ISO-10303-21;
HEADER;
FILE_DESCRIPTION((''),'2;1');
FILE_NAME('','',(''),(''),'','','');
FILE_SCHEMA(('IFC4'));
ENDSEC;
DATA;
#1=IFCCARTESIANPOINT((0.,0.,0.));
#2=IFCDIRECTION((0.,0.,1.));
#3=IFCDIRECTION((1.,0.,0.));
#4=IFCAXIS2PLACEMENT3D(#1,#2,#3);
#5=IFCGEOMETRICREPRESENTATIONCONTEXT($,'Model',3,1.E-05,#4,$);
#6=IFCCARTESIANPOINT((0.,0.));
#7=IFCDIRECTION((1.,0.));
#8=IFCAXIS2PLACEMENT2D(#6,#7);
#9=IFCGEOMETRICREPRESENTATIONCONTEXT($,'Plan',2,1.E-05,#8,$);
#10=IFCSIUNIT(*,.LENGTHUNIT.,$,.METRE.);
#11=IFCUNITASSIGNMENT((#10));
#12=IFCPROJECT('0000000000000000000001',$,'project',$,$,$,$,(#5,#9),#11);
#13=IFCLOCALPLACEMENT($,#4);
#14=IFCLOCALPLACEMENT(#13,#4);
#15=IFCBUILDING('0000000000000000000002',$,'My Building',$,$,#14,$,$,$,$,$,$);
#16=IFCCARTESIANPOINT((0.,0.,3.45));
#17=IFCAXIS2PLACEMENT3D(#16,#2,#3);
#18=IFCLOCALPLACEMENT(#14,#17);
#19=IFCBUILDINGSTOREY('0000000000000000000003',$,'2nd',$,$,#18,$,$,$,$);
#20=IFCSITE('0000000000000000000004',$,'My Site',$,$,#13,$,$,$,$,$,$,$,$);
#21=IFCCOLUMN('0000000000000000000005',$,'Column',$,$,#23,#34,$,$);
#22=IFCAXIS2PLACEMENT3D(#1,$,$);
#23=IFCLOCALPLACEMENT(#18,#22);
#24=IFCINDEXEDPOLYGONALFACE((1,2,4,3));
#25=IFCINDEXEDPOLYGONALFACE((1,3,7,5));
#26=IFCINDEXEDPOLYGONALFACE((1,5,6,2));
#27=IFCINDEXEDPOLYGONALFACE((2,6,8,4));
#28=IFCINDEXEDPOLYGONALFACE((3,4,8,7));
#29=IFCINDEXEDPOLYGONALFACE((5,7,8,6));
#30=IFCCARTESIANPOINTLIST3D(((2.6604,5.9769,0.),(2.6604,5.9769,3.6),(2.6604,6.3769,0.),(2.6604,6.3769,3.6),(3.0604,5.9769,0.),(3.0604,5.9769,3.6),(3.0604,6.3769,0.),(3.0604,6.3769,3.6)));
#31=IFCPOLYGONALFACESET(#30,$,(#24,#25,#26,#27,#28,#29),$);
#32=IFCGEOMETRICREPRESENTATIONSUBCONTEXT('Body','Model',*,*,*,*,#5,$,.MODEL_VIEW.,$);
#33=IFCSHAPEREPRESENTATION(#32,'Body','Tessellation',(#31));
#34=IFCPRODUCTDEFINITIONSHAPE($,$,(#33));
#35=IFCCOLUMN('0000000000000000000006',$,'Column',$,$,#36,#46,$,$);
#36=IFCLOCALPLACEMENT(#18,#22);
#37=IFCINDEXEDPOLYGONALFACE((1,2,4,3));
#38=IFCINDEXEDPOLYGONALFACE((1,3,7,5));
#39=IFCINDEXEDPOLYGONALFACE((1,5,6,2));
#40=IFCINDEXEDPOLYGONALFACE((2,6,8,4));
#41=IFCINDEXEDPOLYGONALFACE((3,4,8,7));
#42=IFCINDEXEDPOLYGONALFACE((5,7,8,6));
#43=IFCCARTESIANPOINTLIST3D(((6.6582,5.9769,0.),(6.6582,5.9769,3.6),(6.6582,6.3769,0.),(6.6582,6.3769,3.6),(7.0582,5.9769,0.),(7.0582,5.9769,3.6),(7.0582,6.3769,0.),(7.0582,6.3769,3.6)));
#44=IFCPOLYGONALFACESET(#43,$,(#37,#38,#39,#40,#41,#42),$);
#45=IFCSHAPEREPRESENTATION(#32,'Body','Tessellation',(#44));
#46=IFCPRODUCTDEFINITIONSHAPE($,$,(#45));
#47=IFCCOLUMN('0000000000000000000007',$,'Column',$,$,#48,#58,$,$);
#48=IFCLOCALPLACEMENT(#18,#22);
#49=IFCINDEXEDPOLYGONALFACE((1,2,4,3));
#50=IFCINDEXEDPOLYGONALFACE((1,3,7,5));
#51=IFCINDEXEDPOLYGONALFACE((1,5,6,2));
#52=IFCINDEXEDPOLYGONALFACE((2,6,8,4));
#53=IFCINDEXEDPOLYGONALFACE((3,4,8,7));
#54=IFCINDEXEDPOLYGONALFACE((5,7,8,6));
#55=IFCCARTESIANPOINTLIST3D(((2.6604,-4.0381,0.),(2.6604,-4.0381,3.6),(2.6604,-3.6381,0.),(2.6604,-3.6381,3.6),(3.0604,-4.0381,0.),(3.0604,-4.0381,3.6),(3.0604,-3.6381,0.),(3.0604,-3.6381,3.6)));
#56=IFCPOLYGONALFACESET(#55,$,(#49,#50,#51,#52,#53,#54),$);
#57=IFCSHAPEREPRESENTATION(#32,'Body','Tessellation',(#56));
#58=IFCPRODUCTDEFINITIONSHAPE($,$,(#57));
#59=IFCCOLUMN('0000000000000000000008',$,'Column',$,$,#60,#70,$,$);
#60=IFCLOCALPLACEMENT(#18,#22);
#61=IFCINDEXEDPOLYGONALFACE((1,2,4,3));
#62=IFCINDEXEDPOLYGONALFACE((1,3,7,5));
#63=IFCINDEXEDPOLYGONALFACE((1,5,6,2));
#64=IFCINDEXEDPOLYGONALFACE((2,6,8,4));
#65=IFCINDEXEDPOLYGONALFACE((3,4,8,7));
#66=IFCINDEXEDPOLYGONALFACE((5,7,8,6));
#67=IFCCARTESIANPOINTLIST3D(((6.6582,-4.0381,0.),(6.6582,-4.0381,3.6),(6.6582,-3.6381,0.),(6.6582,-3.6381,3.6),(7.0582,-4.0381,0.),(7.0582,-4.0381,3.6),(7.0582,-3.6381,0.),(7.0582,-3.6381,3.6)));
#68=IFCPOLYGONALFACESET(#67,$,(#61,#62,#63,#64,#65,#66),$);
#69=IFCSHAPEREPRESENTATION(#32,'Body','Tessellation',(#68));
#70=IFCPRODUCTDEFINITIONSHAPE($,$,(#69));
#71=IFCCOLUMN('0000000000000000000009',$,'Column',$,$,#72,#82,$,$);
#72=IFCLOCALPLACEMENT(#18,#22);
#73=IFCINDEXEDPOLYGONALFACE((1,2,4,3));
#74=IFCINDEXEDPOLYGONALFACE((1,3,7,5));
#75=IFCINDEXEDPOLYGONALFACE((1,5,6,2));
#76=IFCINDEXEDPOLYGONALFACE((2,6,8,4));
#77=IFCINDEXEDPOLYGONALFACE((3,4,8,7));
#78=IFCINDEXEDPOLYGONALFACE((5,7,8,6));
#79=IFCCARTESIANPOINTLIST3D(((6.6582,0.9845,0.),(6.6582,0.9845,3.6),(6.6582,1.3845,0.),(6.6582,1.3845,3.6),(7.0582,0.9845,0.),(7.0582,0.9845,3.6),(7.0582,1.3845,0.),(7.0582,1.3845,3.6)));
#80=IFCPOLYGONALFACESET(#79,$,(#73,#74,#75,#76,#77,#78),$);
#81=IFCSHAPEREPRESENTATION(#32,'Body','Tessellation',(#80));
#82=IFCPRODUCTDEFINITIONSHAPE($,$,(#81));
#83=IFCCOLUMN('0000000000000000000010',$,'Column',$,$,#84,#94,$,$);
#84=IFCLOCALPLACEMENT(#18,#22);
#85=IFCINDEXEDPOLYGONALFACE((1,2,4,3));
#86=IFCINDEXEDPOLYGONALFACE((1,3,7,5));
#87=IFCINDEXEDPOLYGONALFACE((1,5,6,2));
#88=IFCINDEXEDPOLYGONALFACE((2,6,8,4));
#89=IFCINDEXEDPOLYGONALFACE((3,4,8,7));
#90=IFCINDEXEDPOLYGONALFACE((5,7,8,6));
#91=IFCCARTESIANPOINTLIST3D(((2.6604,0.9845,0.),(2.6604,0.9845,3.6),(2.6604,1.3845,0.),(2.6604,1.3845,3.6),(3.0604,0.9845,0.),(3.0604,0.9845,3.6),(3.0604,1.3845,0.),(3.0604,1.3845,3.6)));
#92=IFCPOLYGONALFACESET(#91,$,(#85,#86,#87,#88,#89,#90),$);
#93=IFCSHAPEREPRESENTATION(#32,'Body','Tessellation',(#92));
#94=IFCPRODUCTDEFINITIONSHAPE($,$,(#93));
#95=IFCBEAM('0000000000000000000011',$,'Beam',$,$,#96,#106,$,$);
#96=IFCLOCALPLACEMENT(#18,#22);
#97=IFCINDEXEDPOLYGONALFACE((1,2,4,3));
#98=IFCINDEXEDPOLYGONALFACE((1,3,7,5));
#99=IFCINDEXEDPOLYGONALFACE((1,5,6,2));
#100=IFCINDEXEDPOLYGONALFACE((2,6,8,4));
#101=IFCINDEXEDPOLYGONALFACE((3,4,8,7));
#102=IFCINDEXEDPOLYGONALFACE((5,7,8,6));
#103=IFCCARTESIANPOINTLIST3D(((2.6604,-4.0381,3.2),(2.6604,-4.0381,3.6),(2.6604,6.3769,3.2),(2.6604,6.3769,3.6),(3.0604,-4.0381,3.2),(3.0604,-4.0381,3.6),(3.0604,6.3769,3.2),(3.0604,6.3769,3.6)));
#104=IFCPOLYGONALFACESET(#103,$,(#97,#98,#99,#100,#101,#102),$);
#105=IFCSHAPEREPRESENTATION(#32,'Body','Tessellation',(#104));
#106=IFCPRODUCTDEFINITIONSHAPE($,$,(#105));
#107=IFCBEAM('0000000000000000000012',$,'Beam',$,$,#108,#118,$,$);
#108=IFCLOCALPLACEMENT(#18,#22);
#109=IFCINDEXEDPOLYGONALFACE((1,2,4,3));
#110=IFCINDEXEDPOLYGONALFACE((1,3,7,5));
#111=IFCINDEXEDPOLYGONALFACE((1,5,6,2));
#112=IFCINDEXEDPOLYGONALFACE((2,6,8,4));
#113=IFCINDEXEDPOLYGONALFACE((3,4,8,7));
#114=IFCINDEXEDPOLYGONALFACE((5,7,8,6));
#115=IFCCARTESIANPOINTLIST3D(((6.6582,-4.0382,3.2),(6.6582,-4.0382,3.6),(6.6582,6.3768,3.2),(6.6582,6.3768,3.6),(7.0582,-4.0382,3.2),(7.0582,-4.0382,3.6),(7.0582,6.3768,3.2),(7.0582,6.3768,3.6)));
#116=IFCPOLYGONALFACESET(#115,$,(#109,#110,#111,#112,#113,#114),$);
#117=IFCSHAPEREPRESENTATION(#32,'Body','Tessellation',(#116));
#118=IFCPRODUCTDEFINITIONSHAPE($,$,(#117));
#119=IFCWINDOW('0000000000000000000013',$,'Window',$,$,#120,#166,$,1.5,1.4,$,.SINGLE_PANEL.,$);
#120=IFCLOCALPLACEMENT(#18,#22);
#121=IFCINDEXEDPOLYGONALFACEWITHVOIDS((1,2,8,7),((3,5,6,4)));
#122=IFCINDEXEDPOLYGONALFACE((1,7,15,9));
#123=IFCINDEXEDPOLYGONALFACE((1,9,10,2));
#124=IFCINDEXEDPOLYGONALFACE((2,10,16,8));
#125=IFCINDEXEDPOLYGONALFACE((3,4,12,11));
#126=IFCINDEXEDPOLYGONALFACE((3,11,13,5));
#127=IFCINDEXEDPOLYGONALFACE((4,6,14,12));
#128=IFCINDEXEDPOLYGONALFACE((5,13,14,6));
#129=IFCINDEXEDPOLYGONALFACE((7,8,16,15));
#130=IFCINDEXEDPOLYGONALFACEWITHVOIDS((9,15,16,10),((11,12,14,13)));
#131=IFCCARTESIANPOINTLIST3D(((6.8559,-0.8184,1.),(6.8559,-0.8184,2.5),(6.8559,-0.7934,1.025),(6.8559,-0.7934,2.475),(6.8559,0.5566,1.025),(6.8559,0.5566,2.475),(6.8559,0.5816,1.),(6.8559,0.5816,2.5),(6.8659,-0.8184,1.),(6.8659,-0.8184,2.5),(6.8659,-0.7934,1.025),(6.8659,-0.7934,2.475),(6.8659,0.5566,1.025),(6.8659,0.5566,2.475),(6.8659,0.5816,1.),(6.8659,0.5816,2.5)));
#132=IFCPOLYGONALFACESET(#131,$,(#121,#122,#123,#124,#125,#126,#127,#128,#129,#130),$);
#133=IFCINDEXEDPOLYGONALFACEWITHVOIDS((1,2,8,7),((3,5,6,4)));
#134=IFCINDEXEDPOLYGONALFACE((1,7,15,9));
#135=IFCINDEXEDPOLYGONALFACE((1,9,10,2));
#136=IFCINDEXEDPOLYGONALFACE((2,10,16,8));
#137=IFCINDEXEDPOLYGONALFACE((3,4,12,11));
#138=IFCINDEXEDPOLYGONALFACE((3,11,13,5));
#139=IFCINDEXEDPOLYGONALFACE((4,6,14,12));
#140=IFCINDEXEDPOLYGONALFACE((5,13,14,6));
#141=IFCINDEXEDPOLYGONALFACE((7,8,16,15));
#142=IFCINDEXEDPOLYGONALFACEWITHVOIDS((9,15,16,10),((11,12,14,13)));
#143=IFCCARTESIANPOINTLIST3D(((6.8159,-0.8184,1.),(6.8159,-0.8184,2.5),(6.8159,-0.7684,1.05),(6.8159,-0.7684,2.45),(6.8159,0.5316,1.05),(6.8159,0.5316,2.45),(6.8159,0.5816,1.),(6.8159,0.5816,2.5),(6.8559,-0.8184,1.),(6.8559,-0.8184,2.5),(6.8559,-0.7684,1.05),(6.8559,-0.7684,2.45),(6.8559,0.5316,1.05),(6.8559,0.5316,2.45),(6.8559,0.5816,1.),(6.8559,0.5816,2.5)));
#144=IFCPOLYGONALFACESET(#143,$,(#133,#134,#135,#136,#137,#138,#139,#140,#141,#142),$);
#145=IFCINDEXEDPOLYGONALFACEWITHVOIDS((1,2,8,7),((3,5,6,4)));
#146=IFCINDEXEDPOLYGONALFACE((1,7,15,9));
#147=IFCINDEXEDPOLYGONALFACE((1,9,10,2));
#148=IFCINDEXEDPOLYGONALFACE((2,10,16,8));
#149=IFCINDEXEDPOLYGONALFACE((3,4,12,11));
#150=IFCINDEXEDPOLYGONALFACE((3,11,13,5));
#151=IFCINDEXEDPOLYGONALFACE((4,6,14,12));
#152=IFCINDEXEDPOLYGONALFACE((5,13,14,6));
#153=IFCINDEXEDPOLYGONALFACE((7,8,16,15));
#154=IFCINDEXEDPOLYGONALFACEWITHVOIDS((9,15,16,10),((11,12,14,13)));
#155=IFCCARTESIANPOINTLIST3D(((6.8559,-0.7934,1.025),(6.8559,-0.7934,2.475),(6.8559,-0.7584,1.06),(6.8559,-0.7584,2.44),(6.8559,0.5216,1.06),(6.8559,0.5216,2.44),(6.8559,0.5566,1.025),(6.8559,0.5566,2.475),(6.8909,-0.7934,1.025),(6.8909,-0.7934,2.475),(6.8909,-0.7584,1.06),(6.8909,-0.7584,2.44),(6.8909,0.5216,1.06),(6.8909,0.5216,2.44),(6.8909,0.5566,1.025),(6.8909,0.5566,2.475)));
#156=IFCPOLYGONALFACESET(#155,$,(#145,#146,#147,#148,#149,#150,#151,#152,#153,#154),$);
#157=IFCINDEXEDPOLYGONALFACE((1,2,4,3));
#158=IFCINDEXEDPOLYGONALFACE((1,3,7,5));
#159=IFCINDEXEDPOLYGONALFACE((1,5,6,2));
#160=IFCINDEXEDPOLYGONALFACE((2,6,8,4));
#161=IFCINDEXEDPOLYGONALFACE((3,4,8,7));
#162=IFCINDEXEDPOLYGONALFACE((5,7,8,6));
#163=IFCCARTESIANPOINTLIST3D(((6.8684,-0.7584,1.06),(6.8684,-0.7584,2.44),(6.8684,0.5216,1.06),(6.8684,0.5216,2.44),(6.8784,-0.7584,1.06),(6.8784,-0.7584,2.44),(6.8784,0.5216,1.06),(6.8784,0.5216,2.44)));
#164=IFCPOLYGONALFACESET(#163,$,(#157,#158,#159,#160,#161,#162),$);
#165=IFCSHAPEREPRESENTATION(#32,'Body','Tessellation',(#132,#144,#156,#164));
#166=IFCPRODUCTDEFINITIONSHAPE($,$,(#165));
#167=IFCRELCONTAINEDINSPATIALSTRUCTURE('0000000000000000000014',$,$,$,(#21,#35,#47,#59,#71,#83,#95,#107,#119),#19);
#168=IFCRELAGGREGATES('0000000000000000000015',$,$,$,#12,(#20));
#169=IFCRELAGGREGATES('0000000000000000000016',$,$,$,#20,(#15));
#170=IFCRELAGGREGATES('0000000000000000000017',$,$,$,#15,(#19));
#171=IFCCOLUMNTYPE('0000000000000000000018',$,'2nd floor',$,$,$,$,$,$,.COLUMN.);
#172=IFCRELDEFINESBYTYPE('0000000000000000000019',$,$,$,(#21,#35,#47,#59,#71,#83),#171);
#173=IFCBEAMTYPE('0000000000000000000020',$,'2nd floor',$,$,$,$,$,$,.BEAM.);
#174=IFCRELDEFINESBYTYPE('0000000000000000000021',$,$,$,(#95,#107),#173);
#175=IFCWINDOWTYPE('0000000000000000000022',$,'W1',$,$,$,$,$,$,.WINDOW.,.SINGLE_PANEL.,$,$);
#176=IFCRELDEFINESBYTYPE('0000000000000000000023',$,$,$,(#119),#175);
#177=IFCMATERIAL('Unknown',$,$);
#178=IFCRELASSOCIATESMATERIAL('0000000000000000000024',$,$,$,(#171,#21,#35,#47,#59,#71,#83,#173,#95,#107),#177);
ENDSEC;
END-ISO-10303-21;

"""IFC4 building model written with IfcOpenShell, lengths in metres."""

from ifc_helpers import new_model, entity, si_unit, frame, origin_with_axes, origin_2d_with_axis, place, context, subcontext, project, spatial, line, indexed_curve, rectangle, outline, extrude, shape, source, transform, mapped, material, material_profile, profile_set, profile_usage, type_object, type_shapes, element, save


model = new_model("IFC4")

# Units and contexts
model_context = context("Model", 3, precision=1e-05, world=origin_with_axes())
plan_context = context("Plan", 2, precision=1e-05, world=origin_2d_with_axis())
body_context_1 = subcontext(model_context, "Body", "Model", "MODEL_VIEW")
body_context_2 = subcontext(plan_context, "Body", "Plan", "PLAN_VIEW")
ifc_project = project(units=[si_unit("LENGTHUNIT", "METRE")], contexts=[model_context, plan_context])

# Site, building, storey
site_placement = place(None, origin_with_axes())
site = spatial("IfcSite", under=ifc_project, at=site_placement, Name="My Site")
building_placement = place(site_placement, origin_with_axes())
building = spatial("IfcBuilding", under=site, at=building_placement, Name="My Building")
storey_placement = place(building_placement, frame((0.0, 0.0, 3.45), z_axis=(0.0, 0.0, 1.0), x_axis=(1.0, 0.0, 0.0)))
storey = spatial("IfcBuildingStorey", under=building, at=storey_placement, Name="2nd")

# Columns
ifc_material = material(Name="Unknown")
ifc_material_profile_1 = material_profile(ifc_material, rectangle(XDim=0.4, YDim=0.4))
ifc_profile_set_1 = profile_set([ifc_material_profile_1])
ifc_profile_usage_1 = profile_usage(ifc_profile_set_1, cardinal=5)
column_type = type_object("IfcColumnType", Name="2nd floor", PredefinedType="COLUMN", material=ifc_profile_set_1)
column_1_placement = place(storey_placement, frame((2.8604, 6.1769, 0.0), z_axis=(0.0, 0.0, 1.0), x_axis=(1.0, 0.0, 0.0)))
element("IfcColumn", 1, at=column_1_placement, inside=storey, type_object=column_type, material=ifc_profile_usage_1, Name="Column", context=body_context_1, shape_type="SweptSolid", body=[
    extrude(rectangle(XDim=0.4, YDim=0.4), origin_with_axes(), (0.0, 0.0, 1.0), 3.6),
])
ifc_profile_usage_2 = profile_usage(ifc_profile_set_1, cardinal=5)
column_2_placement = place(storey_placement, frame((6.8582, 6.1769, 0.0), z_axis=(0.0, 0.0, 1.0), x_axis=(1.0, 0.0, 0.0)))
element("IfcColumn", 2, at=column_2_placement, inside=storey, type_object=column_type, material=ifc_profile_usage_2, Name="Column", context=body_context_1, shape_type="SweptSolid", body=[
    extrude(rectangle(XDim=0.4, YDim=0.4), origin_with_axes(), (0.0, 0.0, 1.0), 3.6),
])
ifc_profile_usage_3 = profile_usage(ifc_profile_set_1, cardinal=5)
column_3_placement = place(storey_placement, frame((2.8604, -3.8381, 0.0), z_axis=(0.0, 0.0, 1.0), x_axis=(1.0, 0.0, 0.0)))
element("IfcColumn", 3, at=column_3_placement, inside=storey, type_object=column_type, material=ifc_profile_usage_3, Name="Column", context=body_context_1, shape_type="SweptSolid", body=[
    extrude(rectangle(XDim=0.4, YDim=0.4), origin_with_axes(), (0.0, 0.0, 1.0), 3.6),
])
ifc_profile_usage_4 = profile_usage(ifc_profile_set_1, cardinal=5)
column_4_placement = place(storey_placement, frame((6.8582, -3.8381, 0.0), z_axis=(0.0, 0.0, 1.0), x_axis=(1.0, 0.0, 0.0)))
element("IfcColumn", 4, at=column_4_placement, inside=storey, type_object=column_type, material=ifc_profile_usage_4, Name="Column", context=body_context_1, shape_type="SweptSolid", body=[
    extrude(rectangle(XDim=0.4, YDim=0.4), origin_with_axes(), (0.0, 0.0, 1.0), 3.6),
])
ifc_profile_usage_5 = profile_usage(ifc_profile_set_1, cardinal=5)
column_5_placement = place(storey_placement, frame((6.8582, 1.1845, 0.0), z_axis=(0.0, 0.0, 1.0), x_axis=(1.0, 0.0, 0.0)))
element("IfcColumn", 5, at=column_5_placement, inside=storey, type_object=column_type, material=ifc_profile_usage_5, Name="Column", context=body_context_1, shape_type="SweptSolid", body=[
    extrude(rectangle(XDim=0.4, YDim=0.4), origin_with_axes(), (0.0, 0.0, 1.0), 3.6),
])
ifc_profile_usage_6 = profile_usage(ifc_profile_set_1, cardinal=5)
column_6_placement = place(storey_placement, frame((2.8604, 1.1845, 0.0), z_axis=(0.0, 0.0, 1.0), x_axis=(1.0, 0.0, 0.0)))
element("IfcColumn", 6, at=column_6_placement, inside=storey, type_object=column_type, material=ifc_profile_usage_6, Name="Column", context=body_context_1, shape_type="SweptSolid", body=[
    extrude(rectangle(XDim=0.4, YDim=0.4), origin_with_axes(), (0.0, 0.0, 1.0), 3.6),
])

# Beams
ifc_material_profile_2 = material_profile(ifc_material, rectangle(XDim=0.4, YDim=0.4))
ifc_profile_set_2 = profile_set([ifc_material_profile_2])
ifc_profile_usage_7 = profile_usage(ifc_profile_set_2, cardinal=5)
beam_type = type_object("IfcBeamType", Name="2nd floor", PredefinedType="BEAM", material=ifc_profile_set_2)
beam_1_placement = place(storey_placement, frame((2.8604, 6.3769, 3.4), z_axis=(0.0, -1.0, 0.0), x_axis=(1.0, 0.0, 0.0)))
element("IfcBeam", 7, at=beam_1_placement, inside=storey, type_object=beam_type, material=ifc_profile_usage_7, Name="Beam", context=body_context_1, shape_type="SweptSolid", body=[
    extrude(rectangle(XDim=0.4, YDim=0.4), origin_with_axes(), (0.0, 0.0, 1.0), 10.415),
])
ifc_profile_usage_8 = profile_usage(ifc_profile_set_2, cardinal=5)
beam_2_placement = place(storey_placement, frame((6.8582, 6.3768, 3.4), z_axis=(0.0, -1.0, 0.0), x_axis=(1.0, 0.0, 0.0)))
element("IfcBeam", 8, at=beam_2_placement, inside=storey, type_object=beam_type, material=ifc_profile_usage_8, Name="Beam", context=body_context_1, shape_type="SweptSolid", body=[
    extrude(rectangle(XDim=0.4, YDim=0.4), origin_with_axes(), (0.0, 0.0, 1.0), 10.415),
])

# Window
window_type_1 = type_object("IfcWindowType", Name="W1", PartitioningType="SINGLE_PANEL", PredefinedType="WINDOW")
shared_shape_1 = source(origin_with_axes(), body_context_1, "Body", "SweptSolid", [
    extrude(outline(indexed_curve([(0.0, 0.0), (1.4, 0.0), (1.4, 1.5), (0.0, 1.5)], segments=[line(1, 2, 3, 4, 1)]), holes=[indexed_curve([(0.025, 0.025), (1.375, 0.025), (1.375, 1.475), (0.025, 1.475)], segments=[line(1, 2, 3, 4, 1)])]), frame((0.0, 0.09, 0.0), z_axis=(0.0, -1.0, 0.0), x_axis=(1.0, 0.0, 0.0)), (0.0, 0.0, -1.0), 0.01),
    extrude(outline(indexed_curve([(0.0, 0.0), (1.4, 0.0), (1.4, 1.5), (0.0, 1.5)], segments=[line(1, 2, 3, 4, 1)]), holes=[indexed_curve([(0.05, 0.05), (1.35, 0.05), (1.35, 1.45), (0.05, 1.45)], segments=[line(1, 2, 3, 4, 1)])]), frame((0.0, 0.05, 0.0), z_axis=(0.0, -1.0, 0.0), x_axis=(1.0, 0.0, 0.0)), (0.0, 0.0, -1.0), 0.04),
    extrude(outline(indexed_curve([(0.0, 0.0), (1.35, 0.0), (1.35, 1.45), (0.0, 1.45)], segments=[line(1, 2, 3, 4, 1)]), holes=[indexed_curve([(0.035, 0.035), (1.315, 0.035), (1.315, 1.415), (0.035, 1.415)], segments=[line(1, 2, 3, 4, 1)])]), frame((0.025, 0.09, 0.025), z_axis=(0.0, -1.0, 0.0), x_axis=(1.0, 0.0, 0.0)), (0.0, 0.0, -1.0), 0.035),
    extrude(outline(indexed_curve([(0.035, 0.035), (1.315, 0.035), (1.315, 1.415), (0.035, 1.415)], segments=[line(1, 2, 3, 4, 1)])), frame((0.025, 0.1025, 0.025), z_axis=(0.0, -1.0, 0.0), x_axis=(1.0, 0.0, 0.0)), (0.0, 0.0, -1.0), 0.01),
])
shared_shape_2 = source(origin_with_axes(), body_context_2, "Body", "Curve2D", [
    entity("IfcIndexedPolyCurve", entity("IfcCartesianPointList2D", [[0.05, 0.05], [1.35, 0.05]])),
    entity("IfcIndexedPolyCurve", entity("IfcCartesianPointList2D", [[0.0, 0.1], [0.025, 0.1], [0.025, 0.09], [0.05, 0.09], [0.05, 0.05], [0.0, 0.05]]), [entity("IfcLineIndex", [1, 2, 3, 4, 5, 6, 1])]),
    entity("IfcIndexedPolyCurve", entity("IfcCartesianPointList2D", [[1.4, 0.1], [1.375, 0.1], [1.375, 0.09], [1.35, 0.09], [1.35, 0.05], [1.4, 0.05]]), [entity("IfcLineIndex", [1, 2, 3, 4, 5, 6, 1])]),
    entity("IfcIndexedPolyCurve", entity("IfcCartesianPointList2D", [[0.025, 0.09], [0.06, 0.09], [0.06, 0.125], [0.025, 0.125]]), [entity("IfcLineIndex", [1, 2, 3, 4, 1])]),
    entity("IfcIndexedPolyCurve", entity("IfcCartesianPointList2D", [[1.375, 0.09], [1.34, 0.09], [1.34, 0.125], [1.375, 0.125]]), [entity("IfcLineIndex", [1, 2, 3, 4, 1])]),
    entity("IfcIndexedPolyCurve", entity("IfcCartesianPointList2D", [[0.06, 0.09], [1.34, 0.09]])),
    entity("IfcIndexedPolyCurve", entity("IfcCartesianPointList2D", [[0.06, 0.125], [1.34, 0.125]])),
    entity("IfcIndexedPolyCurve", entity("IfcCartesianPointList2D", [[0.06, 0.1075], [1.34, 0.1075]])),
])
type_shapes(window_type_1, [shared_shape_1, shared_shape_2])
wall_1_placement = place(storey_placement, frame((6.9659, -3.9253, 0.0), z_axis=(0.0, 0.0, 1.0), x_axis=(0.0, 1.0, 0.0)))
opening_1_placement = place(wall_1_placement, frame((4.5069, 0.2, 1.0), z_axis=(0.0, 0.0, 1.0), x_axis=(-1.0, 0.0, 0.0)))
window_1_placement = place(opening_1_placement, frame((0.0, 0.0, 0.0), z_axis=(0.0, 0.0, 1.0), x_axis=(1.0, 0.0, 0.0)))
element("IfcWindow", 9, at=window_1_placement, inside=storey, type_object=window_type_1, Name="Window", OverallHeight=1.5, OverallWidth=1.4, PartitioningType="SINGLE_PANEL", shapes=[
    shape(body_context_1, "Body", "MappedRepresentation", [mapped(shared_shape_1, transform((0.0, 0.0, 0.0), x_axis=(1.0, 0.0, 0.0), y_axis=(0.0, 1.0, 0.0), z_axis=(0.0, 0.0, 1.0), scale=1.0))]),
    shape(body_context_2, "Body", "MappedRepresentation", [mapped(shared_shape_2, transform((0.0, 0.0, 0.0), x_axis=(1.0, 0.0, 0.0), y_axis=(0.0, 1.0, 0.0), z_axis=(0.0, 0.0, 1.0), scale=1.0))]),
])

save(model, "model.ifc")
